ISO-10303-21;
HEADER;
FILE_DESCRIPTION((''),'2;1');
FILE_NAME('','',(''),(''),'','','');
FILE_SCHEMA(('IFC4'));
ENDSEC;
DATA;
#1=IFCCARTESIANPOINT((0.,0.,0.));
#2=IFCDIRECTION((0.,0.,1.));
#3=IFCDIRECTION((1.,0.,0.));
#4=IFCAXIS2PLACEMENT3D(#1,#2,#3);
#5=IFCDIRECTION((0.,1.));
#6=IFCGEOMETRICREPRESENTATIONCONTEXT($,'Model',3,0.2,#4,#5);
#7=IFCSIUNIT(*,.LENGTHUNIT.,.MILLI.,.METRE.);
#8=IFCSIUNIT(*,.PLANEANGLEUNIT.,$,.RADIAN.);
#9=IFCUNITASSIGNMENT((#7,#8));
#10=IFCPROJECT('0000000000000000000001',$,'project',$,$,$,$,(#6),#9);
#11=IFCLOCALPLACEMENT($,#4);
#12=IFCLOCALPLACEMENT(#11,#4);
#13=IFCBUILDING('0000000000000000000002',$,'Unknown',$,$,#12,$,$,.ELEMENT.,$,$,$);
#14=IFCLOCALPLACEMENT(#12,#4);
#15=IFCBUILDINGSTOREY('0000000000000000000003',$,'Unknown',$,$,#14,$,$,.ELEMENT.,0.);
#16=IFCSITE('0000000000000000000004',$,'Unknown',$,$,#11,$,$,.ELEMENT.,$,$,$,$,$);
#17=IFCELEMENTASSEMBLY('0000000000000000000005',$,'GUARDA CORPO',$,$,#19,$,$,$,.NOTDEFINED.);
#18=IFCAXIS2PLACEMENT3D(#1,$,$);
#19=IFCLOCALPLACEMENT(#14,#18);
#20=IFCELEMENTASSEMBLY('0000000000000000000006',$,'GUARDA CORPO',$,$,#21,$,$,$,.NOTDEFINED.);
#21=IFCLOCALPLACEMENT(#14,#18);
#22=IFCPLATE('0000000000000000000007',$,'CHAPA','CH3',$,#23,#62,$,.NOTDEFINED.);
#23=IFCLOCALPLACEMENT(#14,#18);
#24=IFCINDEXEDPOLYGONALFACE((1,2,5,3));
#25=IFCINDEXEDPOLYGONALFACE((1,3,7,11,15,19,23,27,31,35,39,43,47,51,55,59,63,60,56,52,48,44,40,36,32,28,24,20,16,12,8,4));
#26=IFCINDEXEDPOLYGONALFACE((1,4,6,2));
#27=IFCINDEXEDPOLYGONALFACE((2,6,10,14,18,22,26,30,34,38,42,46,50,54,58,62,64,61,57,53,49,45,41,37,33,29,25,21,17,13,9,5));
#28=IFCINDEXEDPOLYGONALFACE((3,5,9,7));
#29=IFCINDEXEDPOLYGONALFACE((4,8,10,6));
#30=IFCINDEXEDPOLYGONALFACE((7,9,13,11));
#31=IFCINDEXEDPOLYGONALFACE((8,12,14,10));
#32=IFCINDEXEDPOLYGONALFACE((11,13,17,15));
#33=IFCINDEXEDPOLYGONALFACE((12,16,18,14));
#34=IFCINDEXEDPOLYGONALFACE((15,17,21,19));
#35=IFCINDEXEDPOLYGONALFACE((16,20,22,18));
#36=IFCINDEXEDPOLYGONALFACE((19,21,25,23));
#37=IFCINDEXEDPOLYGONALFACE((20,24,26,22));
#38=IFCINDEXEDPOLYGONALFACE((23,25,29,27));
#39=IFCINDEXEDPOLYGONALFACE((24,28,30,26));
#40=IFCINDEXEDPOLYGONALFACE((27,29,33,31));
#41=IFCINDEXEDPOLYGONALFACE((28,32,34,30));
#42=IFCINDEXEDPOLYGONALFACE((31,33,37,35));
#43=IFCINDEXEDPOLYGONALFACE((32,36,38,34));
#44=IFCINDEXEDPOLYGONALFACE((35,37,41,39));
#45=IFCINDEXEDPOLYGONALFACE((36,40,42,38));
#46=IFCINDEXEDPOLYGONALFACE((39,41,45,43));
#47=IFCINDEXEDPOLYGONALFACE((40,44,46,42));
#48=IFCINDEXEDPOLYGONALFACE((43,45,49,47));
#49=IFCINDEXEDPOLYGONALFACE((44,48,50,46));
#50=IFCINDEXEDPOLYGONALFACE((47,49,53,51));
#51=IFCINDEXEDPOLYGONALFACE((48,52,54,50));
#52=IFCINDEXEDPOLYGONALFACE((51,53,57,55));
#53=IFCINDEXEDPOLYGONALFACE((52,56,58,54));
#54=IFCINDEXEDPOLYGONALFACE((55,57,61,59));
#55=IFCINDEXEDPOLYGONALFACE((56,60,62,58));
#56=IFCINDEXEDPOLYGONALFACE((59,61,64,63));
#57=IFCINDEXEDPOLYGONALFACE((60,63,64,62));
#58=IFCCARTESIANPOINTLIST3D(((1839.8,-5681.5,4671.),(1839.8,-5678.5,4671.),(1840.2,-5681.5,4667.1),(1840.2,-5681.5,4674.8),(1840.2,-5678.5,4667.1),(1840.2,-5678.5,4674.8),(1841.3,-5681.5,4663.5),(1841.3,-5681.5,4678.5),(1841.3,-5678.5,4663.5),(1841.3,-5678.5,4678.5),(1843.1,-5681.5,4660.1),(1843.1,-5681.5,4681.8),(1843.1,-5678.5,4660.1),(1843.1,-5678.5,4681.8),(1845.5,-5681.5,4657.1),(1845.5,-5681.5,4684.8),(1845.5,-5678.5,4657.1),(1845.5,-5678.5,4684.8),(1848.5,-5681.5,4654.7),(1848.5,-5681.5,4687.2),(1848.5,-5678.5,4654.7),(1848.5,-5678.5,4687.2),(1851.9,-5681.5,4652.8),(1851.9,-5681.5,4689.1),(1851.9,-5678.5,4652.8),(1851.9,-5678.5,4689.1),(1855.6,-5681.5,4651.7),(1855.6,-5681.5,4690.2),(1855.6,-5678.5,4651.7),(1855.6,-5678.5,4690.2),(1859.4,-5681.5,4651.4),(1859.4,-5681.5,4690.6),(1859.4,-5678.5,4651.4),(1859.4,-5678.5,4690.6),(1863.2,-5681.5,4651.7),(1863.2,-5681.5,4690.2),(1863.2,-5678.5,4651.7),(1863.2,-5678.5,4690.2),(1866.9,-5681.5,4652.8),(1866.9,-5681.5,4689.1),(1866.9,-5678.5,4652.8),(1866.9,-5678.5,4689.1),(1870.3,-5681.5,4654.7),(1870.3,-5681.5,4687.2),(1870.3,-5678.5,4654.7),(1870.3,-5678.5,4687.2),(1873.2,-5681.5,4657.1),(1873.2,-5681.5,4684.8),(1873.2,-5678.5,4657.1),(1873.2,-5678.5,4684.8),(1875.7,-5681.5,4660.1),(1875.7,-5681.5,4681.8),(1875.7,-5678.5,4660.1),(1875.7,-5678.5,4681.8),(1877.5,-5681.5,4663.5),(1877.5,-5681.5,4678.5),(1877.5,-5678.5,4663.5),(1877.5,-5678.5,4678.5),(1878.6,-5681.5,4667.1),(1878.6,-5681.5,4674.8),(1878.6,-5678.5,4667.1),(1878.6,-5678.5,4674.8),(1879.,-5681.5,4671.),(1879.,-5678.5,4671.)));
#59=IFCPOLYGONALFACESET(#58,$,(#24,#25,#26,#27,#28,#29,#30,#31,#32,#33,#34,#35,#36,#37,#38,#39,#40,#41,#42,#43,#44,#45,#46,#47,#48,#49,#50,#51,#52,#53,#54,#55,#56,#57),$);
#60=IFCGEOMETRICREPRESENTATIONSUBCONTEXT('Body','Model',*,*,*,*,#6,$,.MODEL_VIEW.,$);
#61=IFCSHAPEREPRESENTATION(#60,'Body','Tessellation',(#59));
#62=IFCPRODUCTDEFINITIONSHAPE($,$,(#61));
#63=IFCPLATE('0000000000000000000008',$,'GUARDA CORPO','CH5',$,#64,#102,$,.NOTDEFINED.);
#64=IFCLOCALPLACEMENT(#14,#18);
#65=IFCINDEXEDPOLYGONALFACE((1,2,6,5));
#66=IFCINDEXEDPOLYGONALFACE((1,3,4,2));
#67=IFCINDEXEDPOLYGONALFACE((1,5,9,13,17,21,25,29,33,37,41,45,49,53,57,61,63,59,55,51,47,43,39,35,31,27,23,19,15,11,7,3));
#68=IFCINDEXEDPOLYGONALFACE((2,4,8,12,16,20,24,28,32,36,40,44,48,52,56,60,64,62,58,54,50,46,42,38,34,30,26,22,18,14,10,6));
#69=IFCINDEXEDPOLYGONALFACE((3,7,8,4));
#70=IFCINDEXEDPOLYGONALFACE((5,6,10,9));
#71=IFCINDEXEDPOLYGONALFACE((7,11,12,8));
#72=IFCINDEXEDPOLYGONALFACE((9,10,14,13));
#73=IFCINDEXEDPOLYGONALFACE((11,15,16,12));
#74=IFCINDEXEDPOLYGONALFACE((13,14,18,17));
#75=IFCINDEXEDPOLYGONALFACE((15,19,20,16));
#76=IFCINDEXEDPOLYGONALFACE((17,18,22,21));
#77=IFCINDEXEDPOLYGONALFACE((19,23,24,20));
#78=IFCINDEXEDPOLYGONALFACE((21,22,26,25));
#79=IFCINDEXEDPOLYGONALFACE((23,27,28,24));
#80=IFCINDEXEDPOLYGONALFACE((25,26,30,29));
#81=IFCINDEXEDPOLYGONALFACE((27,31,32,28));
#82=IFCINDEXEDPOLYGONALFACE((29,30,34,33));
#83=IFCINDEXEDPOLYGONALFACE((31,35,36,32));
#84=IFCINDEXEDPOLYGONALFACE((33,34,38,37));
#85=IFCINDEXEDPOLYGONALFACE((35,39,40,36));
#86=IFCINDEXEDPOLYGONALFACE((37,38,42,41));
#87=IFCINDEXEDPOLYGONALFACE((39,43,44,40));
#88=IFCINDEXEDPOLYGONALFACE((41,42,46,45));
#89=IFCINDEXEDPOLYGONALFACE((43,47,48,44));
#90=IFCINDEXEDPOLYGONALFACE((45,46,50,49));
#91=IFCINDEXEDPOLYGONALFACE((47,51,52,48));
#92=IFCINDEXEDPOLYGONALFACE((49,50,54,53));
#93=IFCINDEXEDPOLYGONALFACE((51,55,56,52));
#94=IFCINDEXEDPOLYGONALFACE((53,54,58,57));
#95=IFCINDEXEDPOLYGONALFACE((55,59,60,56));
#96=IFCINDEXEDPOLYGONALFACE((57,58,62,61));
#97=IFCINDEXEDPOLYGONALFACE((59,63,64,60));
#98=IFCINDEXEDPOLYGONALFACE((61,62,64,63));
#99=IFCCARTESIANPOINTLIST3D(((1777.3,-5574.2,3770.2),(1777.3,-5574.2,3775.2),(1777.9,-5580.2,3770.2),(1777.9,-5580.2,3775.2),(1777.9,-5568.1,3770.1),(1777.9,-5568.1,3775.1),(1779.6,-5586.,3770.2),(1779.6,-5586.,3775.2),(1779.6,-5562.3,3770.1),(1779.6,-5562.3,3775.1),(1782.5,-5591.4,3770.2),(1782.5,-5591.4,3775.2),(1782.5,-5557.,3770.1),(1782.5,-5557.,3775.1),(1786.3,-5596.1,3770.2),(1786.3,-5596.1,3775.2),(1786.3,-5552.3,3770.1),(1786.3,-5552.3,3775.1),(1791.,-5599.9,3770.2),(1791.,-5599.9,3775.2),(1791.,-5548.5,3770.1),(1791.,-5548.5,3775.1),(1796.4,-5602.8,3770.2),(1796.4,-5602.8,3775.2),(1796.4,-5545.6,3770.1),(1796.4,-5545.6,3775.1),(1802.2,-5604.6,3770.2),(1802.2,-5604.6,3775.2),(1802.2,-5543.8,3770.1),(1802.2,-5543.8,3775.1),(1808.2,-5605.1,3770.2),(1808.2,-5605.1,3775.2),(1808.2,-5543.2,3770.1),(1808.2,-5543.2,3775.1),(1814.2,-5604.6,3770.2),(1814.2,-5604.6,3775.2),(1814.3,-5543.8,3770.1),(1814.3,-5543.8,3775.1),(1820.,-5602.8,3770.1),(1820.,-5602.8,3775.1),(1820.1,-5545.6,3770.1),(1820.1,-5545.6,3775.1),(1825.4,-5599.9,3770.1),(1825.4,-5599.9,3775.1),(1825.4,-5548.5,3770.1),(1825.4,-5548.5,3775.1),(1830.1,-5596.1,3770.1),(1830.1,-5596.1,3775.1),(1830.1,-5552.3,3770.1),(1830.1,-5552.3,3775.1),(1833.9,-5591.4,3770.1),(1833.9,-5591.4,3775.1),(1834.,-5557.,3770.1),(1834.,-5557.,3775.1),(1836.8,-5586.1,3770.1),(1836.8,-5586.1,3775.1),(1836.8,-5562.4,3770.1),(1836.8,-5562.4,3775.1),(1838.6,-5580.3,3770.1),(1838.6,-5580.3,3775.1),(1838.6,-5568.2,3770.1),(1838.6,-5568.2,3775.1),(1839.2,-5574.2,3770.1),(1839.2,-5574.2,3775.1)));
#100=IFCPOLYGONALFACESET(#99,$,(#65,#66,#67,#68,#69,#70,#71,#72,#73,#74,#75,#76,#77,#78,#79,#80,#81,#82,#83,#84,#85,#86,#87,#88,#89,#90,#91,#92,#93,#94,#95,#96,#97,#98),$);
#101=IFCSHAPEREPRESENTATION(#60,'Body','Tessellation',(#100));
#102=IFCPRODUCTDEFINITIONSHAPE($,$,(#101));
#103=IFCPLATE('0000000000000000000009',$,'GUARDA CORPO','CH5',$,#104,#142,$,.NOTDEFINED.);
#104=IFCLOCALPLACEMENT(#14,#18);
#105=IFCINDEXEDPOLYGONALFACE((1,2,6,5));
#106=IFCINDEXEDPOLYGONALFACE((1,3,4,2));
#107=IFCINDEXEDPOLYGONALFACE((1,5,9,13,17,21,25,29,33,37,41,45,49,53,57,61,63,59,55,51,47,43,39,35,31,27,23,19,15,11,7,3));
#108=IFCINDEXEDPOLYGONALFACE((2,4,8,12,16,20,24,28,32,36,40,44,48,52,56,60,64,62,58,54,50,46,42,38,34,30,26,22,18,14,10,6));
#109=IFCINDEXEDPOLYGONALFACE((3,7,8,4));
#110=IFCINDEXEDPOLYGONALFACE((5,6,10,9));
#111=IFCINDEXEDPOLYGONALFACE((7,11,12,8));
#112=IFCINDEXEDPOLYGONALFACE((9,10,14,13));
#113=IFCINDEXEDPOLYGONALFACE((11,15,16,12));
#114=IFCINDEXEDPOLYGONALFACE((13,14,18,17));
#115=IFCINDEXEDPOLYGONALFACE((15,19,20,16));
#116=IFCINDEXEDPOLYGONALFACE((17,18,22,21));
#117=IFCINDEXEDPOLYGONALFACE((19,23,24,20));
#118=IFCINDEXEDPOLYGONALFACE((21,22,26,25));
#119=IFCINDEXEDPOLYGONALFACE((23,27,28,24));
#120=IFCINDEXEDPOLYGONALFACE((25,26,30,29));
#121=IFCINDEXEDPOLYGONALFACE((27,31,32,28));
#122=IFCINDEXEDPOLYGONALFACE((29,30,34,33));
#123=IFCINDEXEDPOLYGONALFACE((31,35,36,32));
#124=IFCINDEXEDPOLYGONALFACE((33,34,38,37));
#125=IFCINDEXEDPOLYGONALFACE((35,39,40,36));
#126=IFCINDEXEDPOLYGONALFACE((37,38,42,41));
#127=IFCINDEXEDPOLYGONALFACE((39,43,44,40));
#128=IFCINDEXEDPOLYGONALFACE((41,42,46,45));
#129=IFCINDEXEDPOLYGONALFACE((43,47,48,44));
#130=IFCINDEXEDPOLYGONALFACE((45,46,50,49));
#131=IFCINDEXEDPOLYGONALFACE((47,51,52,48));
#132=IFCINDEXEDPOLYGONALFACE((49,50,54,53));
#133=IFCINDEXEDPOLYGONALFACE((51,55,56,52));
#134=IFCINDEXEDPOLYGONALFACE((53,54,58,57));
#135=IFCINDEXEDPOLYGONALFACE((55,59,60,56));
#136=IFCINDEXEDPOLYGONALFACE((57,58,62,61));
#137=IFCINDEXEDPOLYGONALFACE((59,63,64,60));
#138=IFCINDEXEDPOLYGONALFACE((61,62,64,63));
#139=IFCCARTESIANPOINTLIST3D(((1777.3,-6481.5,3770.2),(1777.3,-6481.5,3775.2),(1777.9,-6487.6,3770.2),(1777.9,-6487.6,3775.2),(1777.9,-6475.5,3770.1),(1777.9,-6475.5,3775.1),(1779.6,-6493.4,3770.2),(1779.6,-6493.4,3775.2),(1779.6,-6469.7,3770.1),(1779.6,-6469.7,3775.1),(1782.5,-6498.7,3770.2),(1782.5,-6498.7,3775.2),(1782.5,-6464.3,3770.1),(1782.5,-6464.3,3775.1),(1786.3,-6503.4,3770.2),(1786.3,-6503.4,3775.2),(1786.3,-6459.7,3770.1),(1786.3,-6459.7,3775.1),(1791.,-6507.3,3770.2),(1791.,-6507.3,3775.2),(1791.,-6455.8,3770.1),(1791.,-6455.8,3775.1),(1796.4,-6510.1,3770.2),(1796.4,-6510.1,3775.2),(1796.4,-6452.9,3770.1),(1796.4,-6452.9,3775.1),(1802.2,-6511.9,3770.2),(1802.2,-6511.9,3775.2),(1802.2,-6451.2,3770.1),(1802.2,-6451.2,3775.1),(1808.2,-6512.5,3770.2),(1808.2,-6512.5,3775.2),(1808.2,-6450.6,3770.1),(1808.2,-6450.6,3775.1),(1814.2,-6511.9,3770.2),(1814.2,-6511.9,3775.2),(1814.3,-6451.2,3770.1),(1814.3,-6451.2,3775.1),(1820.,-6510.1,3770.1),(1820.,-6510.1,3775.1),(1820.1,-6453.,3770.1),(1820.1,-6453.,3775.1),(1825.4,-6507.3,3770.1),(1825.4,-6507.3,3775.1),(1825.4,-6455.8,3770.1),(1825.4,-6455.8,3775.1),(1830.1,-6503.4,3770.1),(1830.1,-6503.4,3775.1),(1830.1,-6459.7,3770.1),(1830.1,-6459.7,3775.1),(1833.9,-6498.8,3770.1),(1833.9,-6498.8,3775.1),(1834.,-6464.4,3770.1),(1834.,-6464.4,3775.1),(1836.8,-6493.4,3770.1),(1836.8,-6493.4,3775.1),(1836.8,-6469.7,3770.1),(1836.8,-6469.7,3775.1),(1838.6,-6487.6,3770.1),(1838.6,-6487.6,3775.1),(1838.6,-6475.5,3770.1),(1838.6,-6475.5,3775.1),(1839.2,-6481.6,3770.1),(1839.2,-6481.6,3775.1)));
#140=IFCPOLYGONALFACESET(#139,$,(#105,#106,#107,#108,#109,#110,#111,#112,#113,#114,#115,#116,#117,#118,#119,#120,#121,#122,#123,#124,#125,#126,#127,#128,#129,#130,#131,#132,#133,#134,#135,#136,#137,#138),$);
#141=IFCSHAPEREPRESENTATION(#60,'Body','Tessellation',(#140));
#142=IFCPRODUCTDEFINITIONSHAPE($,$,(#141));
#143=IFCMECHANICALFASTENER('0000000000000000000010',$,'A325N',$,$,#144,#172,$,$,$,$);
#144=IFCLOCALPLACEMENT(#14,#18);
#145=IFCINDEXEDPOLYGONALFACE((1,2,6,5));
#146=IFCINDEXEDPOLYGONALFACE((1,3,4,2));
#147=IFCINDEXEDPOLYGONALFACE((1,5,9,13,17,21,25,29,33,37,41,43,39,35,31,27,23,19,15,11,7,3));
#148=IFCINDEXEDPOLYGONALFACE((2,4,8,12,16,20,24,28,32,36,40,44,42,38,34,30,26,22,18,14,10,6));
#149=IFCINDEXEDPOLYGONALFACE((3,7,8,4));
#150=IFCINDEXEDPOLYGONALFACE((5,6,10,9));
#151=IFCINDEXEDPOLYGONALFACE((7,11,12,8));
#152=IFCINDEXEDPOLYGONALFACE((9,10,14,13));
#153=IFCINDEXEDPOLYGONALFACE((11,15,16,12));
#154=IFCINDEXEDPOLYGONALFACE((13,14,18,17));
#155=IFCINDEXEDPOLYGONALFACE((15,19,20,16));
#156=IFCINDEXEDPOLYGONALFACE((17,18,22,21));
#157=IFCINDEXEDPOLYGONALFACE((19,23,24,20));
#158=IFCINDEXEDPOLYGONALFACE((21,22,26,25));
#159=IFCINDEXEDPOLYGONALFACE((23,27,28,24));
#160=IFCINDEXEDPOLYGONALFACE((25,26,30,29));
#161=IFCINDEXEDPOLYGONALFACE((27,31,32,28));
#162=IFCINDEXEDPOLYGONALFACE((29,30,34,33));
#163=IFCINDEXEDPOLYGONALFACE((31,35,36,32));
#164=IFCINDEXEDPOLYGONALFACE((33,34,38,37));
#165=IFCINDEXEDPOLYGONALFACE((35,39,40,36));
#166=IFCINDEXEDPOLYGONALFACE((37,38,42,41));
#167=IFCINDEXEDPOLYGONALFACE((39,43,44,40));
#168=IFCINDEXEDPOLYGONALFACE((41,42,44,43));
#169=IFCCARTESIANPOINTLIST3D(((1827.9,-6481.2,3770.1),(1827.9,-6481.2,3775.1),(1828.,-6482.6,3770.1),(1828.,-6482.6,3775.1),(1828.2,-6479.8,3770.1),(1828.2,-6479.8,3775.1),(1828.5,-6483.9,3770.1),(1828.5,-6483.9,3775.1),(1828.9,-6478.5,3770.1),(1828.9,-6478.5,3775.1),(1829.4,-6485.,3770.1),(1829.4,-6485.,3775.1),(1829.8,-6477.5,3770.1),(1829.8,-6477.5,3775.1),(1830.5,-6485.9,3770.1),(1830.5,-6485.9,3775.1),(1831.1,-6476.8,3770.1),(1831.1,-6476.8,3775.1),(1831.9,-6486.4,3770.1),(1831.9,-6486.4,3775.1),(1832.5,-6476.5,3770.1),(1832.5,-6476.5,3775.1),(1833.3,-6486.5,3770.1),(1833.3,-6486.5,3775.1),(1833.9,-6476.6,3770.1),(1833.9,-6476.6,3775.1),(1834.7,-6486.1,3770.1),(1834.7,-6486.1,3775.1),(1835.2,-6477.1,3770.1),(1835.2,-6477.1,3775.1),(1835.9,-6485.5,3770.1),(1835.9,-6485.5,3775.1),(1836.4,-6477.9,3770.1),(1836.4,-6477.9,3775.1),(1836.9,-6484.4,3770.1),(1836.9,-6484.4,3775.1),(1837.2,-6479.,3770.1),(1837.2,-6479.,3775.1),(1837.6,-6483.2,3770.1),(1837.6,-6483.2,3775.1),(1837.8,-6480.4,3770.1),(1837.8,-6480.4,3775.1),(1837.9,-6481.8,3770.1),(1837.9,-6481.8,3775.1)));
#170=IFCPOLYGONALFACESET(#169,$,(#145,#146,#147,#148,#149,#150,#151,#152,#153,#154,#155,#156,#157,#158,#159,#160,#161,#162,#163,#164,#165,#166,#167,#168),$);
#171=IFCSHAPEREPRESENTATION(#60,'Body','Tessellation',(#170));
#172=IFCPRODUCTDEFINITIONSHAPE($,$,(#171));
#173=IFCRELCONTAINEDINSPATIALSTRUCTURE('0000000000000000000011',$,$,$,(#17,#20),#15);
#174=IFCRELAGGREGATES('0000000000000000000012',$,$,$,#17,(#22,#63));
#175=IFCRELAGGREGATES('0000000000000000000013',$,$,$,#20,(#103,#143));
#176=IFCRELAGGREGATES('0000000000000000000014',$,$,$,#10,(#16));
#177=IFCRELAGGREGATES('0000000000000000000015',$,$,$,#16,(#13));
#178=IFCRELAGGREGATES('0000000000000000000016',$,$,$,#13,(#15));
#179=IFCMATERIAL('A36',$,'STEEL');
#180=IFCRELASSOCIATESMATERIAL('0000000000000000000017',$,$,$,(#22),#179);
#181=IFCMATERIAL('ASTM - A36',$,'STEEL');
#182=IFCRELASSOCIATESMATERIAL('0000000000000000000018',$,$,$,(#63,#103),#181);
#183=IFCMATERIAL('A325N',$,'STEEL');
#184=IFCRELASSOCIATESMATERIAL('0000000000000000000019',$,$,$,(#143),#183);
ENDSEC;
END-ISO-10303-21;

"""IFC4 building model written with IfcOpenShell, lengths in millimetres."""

from ifc_helpers import new_model, si_unit, direction, frame, origin_with_axes, place, context, subcontext, project, spatial, line, arc, indexed_curve, outline, extrude, source, transform, mapped, material, element, aggregate, save


model = new_model("IFC4")

# Units and contexts
model_context = context("Model", 3, precision=0.2, world=origin_with_axes(), true_north=direction((0.0, 1.0)))
body_context = subcontext(model_context, "Body", "Model", "MODEL_VIEW")
ifc_project = project(units=[si_unit("LENGTHUNIT", "METRE", prefix="MILLI"), si_unit("PLANEANGLEUNIT", "RADIAN")], contexts=[model_context])

# Site, building, storey
site_placement = place(None, origin_with_axes())
site = spatial("IfcSite", under=ifc_project, at=site_placement, Name="Unknown", CompositionType="ELEMENT")
building_placement = place(site_placement, origin_with_axes())
building = spatial("IfcBuilding", under=site, at=building_placement, Name="Unknown", CompositionType="ELEMENT")
storey_placement = place(building_placement, origin_with_axes())
storey = spatial("IfcBuildingStorey", under=building, at=storey_placement, Name="Unknown", CompositionType="ELEMENT", Elevation=0.0)

# Element assemblies
ifc_material_1 = material(Name="A36", Category="STEEL")
assembly_1_placement = place(storey_placement, frame((647.5, -5181.6, 2875.0), z_axis=(-0.000512, 1.0, -0.000003), x_axis=(0.000003, 0.000003, 1.0)))
assembly_1 = element("IfcElementAssembly", 1, at=assembly_1_placement, inside=storey, Name="GUARDA CORPO", PredefinedType="NOTDEFINED")
assembly_2_placement = place(storey_placement, frame((1808.2, -6481.4, 3775.1), z_axis=(0.000512, 1.0, -0.000003), x_axis=(0.000003, 0.000003, 1.0)))
assembly_2 = element("IfcElementAssembly", 2, at=assembly_2_placement, inside=storey, Name="GUARDA CORPO", PredefinedType="NOTDEFINED")

# Plates
plate_1_placement = place(assembly_1_placement, frame((1776.7, 1215.4, -499.0), z_axis=(-0.000004, -0.000512, -1.0), x_axis=(0.290288, 0.956939, -0.000492)))
plate_1 = element("IfcPlate", 3, at=plate_1_placement, material=ifc_material_1, Name="CHAPA", Description="CH3", PredefinedType="NOTDEFINED", context=body_context, shape_type="SolidModel", body=[
    extrude(outline(indexed_curve([(0.0, 0.0), (3.8, 0.0), (7.6, 0.7), (11.2, 2.2), (14.4, 4.4), (17.1, 7.1), (19.2, 10.3), (20.7, 13.8), (21.4, 17.6), (21.4, 21.4), (20.7, 25.2), (19.2, 28.7), (17.1, 31.9), (14.4, 34.7), (11.2, 36.8), (7.6, 38.3), (3.8, 39.0), (0.0, 39.0), (-3.8, 38.3), (-7.3, 36.8), (-10.5, 34.7), (-13.2, 31.9), (-15.4, 28.7), (-16.8, 25.2), (-17.6, 21.4), (-17.6, 17.6), (-16.8, 13.8), (-15.4, 10.3), (-13.2, 7.1), (-10.5, 4.4), (-7.3, 2.2), (-3.8, 0.7)], segments=[line(1, 2, 3, 4, 5, 6, 7, 8, 9, 10, 11, 12, 13, 14, 15, 16, 17, 18, 19, 20, 21, 22, 23, 24, 25, 26, 27, 28, 29, 30, 31, 32, 1)])), frame((0.0, 0.0, 1.5), z_axis=(0.0, 0.0, 1.0), x_axis=(1.0, 0.0, 0.0)), (0.0, 0.0, -1.0), 3.0),
])
ifc_material_2 = material(Name="ASTM - A36", Category="STEEL")
plate_2_placement = place(assembly_1_placement, frame((897.6, 1166.5, -362.8), z_axis=(-1.0, 0.0, 0.0), x_axis=(0.0, 0.956642, -0.291265)))
plate_2 = element("IfcPlate", 4, at=plate_2_placement, material=ifc_material_2, Name="GUARDA CORPO", Description="CH5", PredefinedType="NOTDEFINED", context=body_context, shape_type="SolidModel", body=[
    extrude(outline(indexed_curve([(0.0, 0.0), (6.1, 0.0), (12.0, 1.2), (17.6, 3.5), (22.7, 6.9), (27.0, 11.2), (30.3, 16.2), (32.7, 21.8), (33.8, 27.8), (33.8, 33.8), (32.7, 39.8), (30.3, 45.4), (27.0, 50.4), (22.7, 54.7), (17.6, 58.1), (12.0, 60.4), (6.1, 61.6), (0.0, 61.6), (-6.0, 60.4), (-11.6, 58.1), (-16.6, 54.7), (-20.9, 50.4), (-24.3, 45.4), (-26.6, 39.8), (-27.8, 33.8), (-27.8, 27.8), (-26.6, 21.8), (-24.3, 16.2), (-20.9, 11.2), (-16.6, 6.9), (-11.6, 3.5), (-6.0, 1.2)], segments=[line(1, 2, 3, 4, 5, 6, 7, 8, 9, 10, 11, 12, 13, 14, 15, 16, 17, 18, 19, 20, 21, 22, 23, 24, 25, 26, 27, 28, 29, 30, 31, 32, 1)])), frame((0.0, 0.0, 2.5), z_axis=(0.0, 0.0, 1.0), x_axis=(1.0, 0.0, 0.0)), (0.0, 0.0, -1.0), 5.0),
])
plate_3_placement = place(assembly_2_placement, frame((-2.5, 6.0, 30.2), z_axis=(-1.0, 0.0, 0.0), x_axis=(0.0, 0.95694, -0.290285)))
plate_3 = element("IfcPlate", 5, at=plate_3_placement, material=ifc_material_2, Name="GUARDA CORPO", Description="CH5", PredefinedType="NOTDEFINED", context=body_context, shape_type="SolidModel", body=[
    extrude(outline(indexed_curve([(0.0, 0.0), (6.1, 0.0), (12.0, 1.2), (17.6, 3.5), (22.7, 6.9), (27.0, 11.2), (30.3, 16.2), (32.7, 21.8), (33.8, 27.8), (33.8, 33.8), (32.7, 39.8), (30.3, 45.4), (27.0, 50.4), (22.7, 54.7), (17.6, 58.1), (12.0, 60.4), (6.1, 61.6), (0.0, 61.6), (-6.0, 60.4), (-11.6, 58.1), (-16.6, 54.7), (-20.9, 50.4), (-24.3, 45.4), (-26.6, 39.8), (-27.8, 33.8), (-27.8, 27.8), (-26.6, 21.8), (-24.3, 16.2), (-20.9, 11.2), (-16.6, 6.9), (-11.6, 3.5), (-6.0, 1.2)], segments=[line(1, 2, 3, 4, 5, 6, 7, 8, 9, 10, 11, 12, 13, 14, 15, 16, 17, 18, 19, 20, 21, 22, 23, 24, 25, 26, 27, 28, 29, 30, 31, 32, 1)])), frame((0.0, 0.0, 2.5), z_axis=(0.0, 0.0, 1.0), x_axis=(1.0, 0.0, 0.0)), (0.0, 0.0, -1.0), 5.0),
])

# Mechanical fastener
ifc_material_3 = material(Name="A325N", Category="STEEL")
shared_shape_1 = source(origin_with_axes(), body_context, "Body", "SweptSolid", [
    extrude(outline(indexed_curve([(5.0, 0.0), (0.0, 5.0), (-5.0, 0.0), (0.0, -5.0)], segments=[arc(1, 2, 3), arc(3, 4, 1)])), frame((0.0, 0.0, 0.0), z_axis=(0.0, 0.0, -1.0), x_axis=(0.0, 1.0, 0.0)), (0.0, 0.0, 1.0), 5.0),
])
mechanical_fastener_1_placement = place(assembly_2_placement, frame((0.0, 24.6, 0.0), z_axis=(1.0, -0.000001, -0.000004), x_axis=(0.000001, -0.881911, 0.471416)))
mechanical_fastener_1 = element("IfcMechanicalFastener", 6, at=mechanical_fastener_1_placement, material=ifc_material_3, Name="A325N", context=body_context, shape_type="MappedRepresentation", body=[
    mapped(shared_shape_1, transform((0.0, 0.0, 0.0))),
])
aggregate(assembly_1, [plate_1, plate_2])
aggregate(assembly_2, [plate_3, mechanical_fastener_1])

save(model, "model.ifc")
